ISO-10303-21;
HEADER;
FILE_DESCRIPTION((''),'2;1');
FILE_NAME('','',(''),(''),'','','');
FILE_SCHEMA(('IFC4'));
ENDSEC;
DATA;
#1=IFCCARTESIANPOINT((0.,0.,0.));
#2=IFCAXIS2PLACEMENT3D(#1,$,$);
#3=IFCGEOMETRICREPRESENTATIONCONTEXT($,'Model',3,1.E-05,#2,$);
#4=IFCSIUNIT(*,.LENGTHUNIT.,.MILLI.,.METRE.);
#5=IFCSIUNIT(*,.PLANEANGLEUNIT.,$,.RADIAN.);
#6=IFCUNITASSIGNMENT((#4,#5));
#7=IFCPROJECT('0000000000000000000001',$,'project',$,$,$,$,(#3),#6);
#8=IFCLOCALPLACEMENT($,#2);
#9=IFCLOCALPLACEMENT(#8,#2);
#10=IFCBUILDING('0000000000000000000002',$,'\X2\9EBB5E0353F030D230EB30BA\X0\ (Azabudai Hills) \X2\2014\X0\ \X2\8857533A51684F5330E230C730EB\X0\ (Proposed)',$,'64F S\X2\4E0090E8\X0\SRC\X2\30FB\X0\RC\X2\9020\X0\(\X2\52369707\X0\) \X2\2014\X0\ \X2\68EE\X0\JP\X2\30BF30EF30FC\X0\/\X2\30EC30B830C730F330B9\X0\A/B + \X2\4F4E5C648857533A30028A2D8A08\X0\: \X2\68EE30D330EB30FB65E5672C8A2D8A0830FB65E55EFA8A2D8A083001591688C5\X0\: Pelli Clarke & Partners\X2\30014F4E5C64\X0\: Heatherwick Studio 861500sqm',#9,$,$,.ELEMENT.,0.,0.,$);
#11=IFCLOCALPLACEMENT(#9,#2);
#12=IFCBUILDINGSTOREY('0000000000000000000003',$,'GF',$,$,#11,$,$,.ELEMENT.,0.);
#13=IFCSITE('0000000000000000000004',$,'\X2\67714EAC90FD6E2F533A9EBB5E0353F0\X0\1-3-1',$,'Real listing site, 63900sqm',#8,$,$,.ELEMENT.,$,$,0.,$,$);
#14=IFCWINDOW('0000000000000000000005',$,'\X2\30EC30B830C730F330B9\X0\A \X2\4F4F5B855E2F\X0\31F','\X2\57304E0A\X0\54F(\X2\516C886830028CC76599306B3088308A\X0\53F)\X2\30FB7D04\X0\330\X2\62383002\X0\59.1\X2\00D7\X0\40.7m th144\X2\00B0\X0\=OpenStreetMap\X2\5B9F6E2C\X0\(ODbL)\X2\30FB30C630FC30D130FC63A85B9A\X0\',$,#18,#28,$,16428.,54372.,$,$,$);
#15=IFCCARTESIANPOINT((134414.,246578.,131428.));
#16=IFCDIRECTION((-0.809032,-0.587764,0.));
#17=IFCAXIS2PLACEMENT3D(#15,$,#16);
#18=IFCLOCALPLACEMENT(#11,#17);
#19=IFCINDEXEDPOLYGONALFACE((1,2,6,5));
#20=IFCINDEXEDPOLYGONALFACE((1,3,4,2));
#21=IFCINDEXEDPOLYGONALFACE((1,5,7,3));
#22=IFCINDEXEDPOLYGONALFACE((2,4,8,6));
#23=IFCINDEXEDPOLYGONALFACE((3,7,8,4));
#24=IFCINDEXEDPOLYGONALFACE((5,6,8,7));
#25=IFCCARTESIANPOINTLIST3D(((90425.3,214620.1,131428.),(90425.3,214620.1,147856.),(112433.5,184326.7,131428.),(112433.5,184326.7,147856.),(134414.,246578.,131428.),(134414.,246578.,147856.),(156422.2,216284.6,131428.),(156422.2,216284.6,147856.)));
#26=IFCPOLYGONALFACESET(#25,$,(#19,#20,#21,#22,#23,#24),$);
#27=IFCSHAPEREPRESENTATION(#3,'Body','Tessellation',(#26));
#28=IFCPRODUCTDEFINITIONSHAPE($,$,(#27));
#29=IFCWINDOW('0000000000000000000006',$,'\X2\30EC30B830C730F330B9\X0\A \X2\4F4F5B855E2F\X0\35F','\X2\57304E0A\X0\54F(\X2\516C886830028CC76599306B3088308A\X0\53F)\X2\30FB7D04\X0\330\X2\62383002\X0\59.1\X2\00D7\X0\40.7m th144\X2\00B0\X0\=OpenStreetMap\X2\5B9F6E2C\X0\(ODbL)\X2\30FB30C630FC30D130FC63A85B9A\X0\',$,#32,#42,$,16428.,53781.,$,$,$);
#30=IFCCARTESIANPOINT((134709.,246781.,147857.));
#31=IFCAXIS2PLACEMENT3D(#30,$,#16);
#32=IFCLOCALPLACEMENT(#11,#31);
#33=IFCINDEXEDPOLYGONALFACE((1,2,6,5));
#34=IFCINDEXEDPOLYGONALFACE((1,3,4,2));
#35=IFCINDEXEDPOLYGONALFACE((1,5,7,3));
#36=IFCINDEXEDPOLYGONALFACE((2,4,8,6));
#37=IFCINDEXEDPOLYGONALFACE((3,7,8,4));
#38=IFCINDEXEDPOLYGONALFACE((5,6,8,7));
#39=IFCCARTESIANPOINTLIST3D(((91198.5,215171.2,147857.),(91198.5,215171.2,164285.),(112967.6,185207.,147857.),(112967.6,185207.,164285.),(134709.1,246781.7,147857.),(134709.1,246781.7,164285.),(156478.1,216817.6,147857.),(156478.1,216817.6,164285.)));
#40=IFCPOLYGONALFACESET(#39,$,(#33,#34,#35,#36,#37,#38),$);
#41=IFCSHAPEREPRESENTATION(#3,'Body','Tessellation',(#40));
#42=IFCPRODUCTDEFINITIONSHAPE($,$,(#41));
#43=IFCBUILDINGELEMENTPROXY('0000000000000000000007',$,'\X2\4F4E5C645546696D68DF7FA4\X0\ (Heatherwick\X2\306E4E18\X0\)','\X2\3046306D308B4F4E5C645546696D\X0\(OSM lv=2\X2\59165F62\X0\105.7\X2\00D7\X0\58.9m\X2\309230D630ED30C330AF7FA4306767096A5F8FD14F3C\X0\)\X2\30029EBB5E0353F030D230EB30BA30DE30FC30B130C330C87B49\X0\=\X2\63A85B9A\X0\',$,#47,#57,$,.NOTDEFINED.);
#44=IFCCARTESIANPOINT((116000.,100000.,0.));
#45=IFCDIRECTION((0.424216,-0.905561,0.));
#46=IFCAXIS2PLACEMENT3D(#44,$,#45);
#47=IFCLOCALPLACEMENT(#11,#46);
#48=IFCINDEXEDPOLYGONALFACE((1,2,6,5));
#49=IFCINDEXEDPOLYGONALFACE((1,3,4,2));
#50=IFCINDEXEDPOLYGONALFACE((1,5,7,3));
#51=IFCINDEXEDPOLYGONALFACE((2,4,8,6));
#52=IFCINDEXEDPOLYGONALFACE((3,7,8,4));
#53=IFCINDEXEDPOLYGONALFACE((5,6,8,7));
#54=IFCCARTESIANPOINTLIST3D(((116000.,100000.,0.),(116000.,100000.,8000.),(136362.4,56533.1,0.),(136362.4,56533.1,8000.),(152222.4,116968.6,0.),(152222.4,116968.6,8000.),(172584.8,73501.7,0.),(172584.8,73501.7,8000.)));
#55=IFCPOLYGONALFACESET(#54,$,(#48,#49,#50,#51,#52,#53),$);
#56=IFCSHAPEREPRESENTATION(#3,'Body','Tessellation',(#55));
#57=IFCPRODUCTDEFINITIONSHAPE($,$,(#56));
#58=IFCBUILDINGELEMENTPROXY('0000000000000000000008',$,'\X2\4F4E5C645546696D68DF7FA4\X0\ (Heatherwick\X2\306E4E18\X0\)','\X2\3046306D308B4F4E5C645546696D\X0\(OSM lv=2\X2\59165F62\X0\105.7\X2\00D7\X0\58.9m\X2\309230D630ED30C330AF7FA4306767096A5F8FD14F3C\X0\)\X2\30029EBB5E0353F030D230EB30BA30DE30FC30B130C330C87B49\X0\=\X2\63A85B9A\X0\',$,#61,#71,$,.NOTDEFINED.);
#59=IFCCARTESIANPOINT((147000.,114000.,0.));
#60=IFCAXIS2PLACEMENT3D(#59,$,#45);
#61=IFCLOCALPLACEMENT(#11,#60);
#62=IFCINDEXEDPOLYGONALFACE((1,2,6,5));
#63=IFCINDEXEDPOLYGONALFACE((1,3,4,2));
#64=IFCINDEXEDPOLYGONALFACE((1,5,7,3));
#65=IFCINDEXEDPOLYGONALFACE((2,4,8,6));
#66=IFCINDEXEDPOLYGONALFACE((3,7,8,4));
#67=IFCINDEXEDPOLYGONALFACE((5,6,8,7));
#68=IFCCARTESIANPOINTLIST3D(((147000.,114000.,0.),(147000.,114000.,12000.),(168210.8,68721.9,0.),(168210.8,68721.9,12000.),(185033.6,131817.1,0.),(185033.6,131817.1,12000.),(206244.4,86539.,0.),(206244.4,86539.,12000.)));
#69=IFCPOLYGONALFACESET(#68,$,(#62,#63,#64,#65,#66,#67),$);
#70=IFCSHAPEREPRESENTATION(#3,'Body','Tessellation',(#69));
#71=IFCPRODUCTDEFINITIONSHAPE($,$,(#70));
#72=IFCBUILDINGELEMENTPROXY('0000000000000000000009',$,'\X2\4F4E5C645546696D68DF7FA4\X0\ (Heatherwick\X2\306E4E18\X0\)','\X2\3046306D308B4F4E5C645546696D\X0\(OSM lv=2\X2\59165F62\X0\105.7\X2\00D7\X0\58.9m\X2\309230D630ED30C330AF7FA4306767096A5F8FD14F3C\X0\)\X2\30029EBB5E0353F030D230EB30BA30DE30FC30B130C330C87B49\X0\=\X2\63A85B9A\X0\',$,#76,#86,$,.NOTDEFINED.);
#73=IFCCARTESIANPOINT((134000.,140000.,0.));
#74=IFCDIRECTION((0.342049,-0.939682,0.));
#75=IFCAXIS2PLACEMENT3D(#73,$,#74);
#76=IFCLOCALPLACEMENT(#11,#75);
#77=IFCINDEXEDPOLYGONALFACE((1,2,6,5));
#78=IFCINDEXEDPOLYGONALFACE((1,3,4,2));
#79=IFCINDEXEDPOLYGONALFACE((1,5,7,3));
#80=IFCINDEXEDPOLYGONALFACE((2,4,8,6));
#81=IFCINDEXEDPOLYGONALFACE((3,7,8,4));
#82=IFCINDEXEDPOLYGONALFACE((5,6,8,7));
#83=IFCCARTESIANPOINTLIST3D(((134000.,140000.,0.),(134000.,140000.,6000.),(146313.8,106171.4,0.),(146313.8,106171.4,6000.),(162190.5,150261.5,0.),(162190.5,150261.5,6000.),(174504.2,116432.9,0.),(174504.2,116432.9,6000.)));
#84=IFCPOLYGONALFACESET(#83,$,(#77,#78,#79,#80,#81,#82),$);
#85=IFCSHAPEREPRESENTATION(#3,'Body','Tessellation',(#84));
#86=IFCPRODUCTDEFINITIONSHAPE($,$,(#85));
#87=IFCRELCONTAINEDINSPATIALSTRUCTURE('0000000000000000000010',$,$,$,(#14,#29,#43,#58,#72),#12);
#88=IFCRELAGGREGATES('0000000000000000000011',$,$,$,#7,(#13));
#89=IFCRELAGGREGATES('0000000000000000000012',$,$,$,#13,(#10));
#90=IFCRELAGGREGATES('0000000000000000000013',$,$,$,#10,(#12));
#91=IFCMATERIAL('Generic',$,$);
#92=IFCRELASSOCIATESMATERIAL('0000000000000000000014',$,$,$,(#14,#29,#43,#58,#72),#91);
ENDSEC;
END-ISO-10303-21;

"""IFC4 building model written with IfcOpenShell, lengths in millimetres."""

from ifc_helpers import new_model, si_unit, frame, frame_2d, origin, place, context, project, spatial, rectangle, extrude, material, element, save


model = new_model("IFC4")

# Units and contexts
model_context = context("Model", 3, precision=1e-05, world=origin())
ifc_project = project(units=[si_unit("LENGTHUNIT", "METRE", prefix="MILLI"), si_unit("PLANEANGLEUNIT", "RADIAN")], contexts=[model_context])

# Site, building, storey
site_placement = place(None, origin())
site = spatial("IfcSite", under=ifc_project, at=site_placement, Name="東京都港区麻布台1-3-1", ObjectType="Real listing site, 63900sqm", CompositionType="ELEMENT", RefElevation=0.0)
building_placement = place(site_placement, origin())
building = spatial("IfcBuilding", under=site, at=building_placement, Name="麻布台ヒルズ (Azabudai Hills) — 街区全体モデル (Proposed)", ObjectType="64F S一部SRC・RC造(制震) — 森JPタワー/レジデンスA/B + 低層街区。設計: 森ビル・日本設計・日建設計、外装: Pelli Clarke & Partners、低層: Heatherwick Studio 861500sqm", CompositionType="ELEMENT", ElevationOfRefHeight=0.0, ElevationOfTerrain=0.0)
storey_placement = place(building_placement, origin())
storey = spatial("IfcBuildingStorey", under=building, at=storey_placement, Name="GF", CompositionType="ELEMENT", Elevation=0.0)

# Shared definitions
ifc_material = material(Name="Generic")

# Windows
window_1_placement = place(storey_placement, frame((134414.0, 246578.0, 131428.0), x_axis=(-0.809032, -0.587764, 0.0)))
element("IfcWindow", 1, at=window_1_placement, inside=storey, material=ifc_material, Name="レジデンスA 住宅帯31F", Description="地上54F(公表。資料により53F)・約330戸。59.1×40.7m th144°=OpenStreetMap実測(ODbL)・テーパー推定", OverallHeight=16428.0, OverallWidth=54372.0, context=model_context, shape_type="SweptSolid", body=[
    extrude(rectangle(XDim=54372.0, YDim=37444.0, at=frame_2d((27186.0, 18722.0))), frame((134414.0, 246578.0, 131428.0), x_axis=(-0.809032, -0.587764, 0.0)), (0.0, 0.0, 1.0), 16428.0),
])
window_2_placement = place(storey_placement, frame((134709.0, 246781.0, 147857.0), x_axis=(-0.809032, -0.587764, 0.0)))
element("IfcWindow", 2, at=window_2_placement, inside=storey, material=ifc_material, Name="レジデンスA 住宅帯35F", Description="地上54F(公表。資料により53F)・約330戸。59.1×40.7m th144°=OpenStreetMap実測(ODbL)・テーパー推定", OverallHeight=16428.0, OverallWidth=53781.0, context=model_context, shape_type="SweptSolid", body=[
    extrude(rectangle(XDim=53781.0, YDim=37037.0, at=frame_2d((26890.0, 18518.0))), frame((134709.0, 246781.0, 147857.0), x_axis=(-0.809032, -0.587764, 0.0)), (0.0, 0.0, 1.0), 16428.0),
])

# Building element proxies
proxy_1_placement = place(storey_placement, frame((116000.0, 100000.0, 0.0), x_axis=(0.424216, -0.905561, 0.0)))
element("IfcBuildingElementProxy", 3, at=proxy_1_placement, inside=storey, material=ifc_material, Name="低層商業棟群 (Heatherwickの丘)", Description="うねる低層商業(OSM lv=2外形105.7×58.9mをブロック群で有機近似)。麻布台ヒルズマーケット等=推定", PredefinedType="NOTDEFINED", context=model_context, shape_type="SweptSolid", body=[
    extrude(rectangle(XDim=48000.0, YDim=40000.0, at=frame_2d((24000.0, 20000.0))), frame((116000.0, 100000.0, 0.0), x_axis=(0.424216, -0.905561, 0.0)), (0.0, 0.0, 1.0), 8000.0),
])
proxy_2_placement = place(storey_placement, frame((147000.0, 114000.0, 0.0), x_axis=(0.424216, -0.905561, 0.0)))
element("IfcBuildingElementProxy", 4, at=proxy_2_placement, inside=storey, material=ifc_material, Name="低層商業棟群 (Heatherwickの丘)", Description="うねる低層商業(OSM lv=2外形105.7×58.9mをブロック群で有機近似)。麻布台ヒルズマーケット等=推定", PredefinedType="NOTDEFINED", context=model_context, shape_type="SweptSolid", body=[
    extrude(rectangle(XDim=50000.0, YDim=42000.0, at=frame_2d((25000.0, 21000.0))), frame((147000.0, 114000.0, 0.0), x_axis=(0.424216, -0.905561, 0.0)), (0.0, 0.0, 1.0), 12000.0),
])
proxy_3_placement = place(storey_placement, frame((134000.0, 140000.0, 0.0), x_axis=(0.342049, -0.939682, 0.0)))
element("IfcBuildingElementProxy", 5, at=proxy_3_placement, inside=storey, material=ifc_material, Name="低層商業棟群 (Heatherwickの丘)", Description="うねる低層商業(OSM lv=2外形105.7×58.9mをブロック群で有機近似)。麻布台ヒルズマーケット等=推定", PredefinedType="NOTDEFINED", context=model_context, shape_type="SweptSolid", body=[
    extrude(rectangle(XDim=36000.0, YDim=30000.0, at=frame_2d((18000.0, 15000.0))), frame((134000.0, 140000.0, 0.0), x_axis=(0.342049, -0.939682, 0.0)), (0.0, 0.0, 1.0), 6000.0),
])

save(model, "model.ifc")
